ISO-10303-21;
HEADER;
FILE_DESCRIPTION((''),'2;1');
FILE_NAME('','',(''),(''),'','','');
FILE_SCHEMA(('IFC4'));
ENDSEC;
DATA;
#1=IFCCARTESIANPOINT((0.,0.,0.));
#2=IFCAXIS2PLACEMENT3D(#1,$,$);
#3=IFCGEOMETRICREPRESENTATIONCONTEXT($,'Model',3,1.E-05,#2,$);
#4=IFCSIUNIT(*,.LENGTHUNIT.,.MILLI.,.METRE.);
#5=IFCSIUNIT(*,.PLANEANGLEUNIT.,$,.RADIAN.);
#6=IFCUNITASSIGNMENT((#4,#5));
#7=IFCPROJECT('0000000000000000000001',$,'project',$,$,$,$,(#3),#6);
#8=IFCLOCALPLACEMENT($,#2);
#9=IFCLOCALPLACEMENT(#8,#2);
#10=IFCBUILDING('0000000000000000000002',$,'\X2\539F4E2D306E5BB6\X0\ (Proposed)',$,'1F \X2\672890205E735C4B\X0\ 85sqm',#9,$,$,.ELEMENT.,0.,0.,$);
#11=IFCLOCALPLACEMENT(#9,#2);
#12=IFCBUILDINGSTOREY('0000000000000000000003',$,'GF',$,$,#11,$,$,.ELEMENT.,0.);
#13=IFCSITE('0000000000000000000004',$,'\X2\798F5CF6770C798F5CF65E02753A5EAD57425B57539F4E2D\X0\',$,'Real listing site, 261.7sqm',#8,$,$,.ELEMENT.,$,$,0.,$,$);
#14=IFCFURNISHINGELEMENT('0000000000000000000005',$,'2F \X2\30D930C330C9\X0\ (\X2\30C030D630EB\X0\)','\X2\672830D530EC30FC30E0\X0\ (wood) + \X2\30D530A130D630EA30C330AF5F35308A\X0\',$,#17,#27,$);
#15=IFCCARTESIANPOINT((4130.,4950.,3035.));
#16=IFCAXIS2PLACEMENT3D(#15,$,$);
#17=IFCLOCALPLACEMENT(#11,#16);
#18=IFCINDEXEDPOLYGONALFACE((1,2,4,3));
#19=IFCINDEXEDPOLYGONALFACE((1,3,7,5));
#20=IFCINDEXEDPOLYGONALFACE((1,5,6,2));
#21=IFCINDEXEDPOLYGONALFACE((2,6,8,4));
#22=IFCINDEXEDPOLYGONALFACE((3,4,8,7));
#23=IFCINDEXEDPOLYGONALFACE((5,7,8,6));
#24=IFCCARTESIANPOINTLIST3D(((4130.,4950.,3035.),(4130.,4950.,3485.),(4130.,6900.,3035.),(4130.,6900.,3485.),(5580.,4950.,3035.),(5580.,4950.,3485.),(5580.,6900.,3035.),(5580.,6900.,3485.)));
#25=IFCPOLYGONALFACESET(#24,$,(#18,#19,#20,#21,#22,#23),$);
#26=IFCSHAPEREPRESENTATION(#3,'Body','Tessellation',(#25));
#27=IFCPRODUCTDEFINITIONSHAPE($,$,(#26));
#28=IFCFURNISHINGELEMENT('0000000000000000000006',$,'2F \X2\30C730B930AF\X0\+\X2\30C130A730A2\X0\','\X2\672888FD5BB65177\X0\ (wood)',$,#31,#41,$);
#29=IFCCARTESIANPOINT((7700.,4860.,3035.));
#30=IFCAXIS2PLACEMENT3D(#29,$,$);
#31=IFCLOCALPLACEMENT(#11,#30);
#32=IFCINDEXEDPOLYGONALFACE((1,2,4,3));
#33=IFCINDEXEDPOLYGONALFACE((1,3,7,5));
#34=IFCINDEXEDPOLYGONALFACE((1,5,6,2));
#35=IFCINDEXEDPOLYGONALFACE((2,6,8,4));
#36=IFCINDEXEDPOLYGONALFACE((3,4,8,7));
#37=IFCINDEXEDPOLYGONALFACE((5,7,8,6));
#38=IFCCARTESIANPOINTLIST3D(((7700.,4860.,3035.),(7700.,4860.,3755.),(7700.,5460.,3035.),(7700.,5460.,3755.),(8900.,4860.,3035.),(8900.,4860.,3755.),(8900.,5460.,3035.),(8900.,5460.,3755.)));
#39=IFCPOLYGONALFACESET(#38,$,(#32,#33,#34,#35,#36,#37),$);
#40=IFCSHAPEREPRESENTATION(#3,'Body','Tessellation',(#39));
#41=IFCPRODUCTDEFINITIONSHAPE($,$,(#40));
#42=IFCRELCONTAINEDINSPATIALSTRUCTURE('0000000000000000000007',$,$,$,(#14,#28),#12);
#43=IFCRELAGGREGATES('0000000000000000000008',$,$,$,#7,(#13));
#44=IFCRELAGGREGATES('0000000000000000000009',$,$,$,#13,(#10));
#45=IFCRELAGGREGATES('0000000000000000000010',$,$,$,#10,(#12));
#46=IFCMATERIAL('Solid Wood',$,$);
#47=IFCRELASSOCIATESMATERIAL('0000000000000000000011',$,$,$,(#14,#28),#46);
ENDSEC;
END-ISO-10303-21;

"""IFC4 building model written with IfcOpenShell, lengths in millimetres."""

from ifc_helpers import new_model, si_unit, frame, frame_2d, origin, place, context, project, spatial, rectangle, extrude, material, element, save


model = new_model("IFC4")

# Units and contexts
model_context = context("Model", 3, precision=1e-05, world=origin())
ifc_project = project(units=[si_unit("LENGTHUNIT", "METRE", prefix="MILLI"), si_unit("PLANEANGLEUNIT", "RADIAN")], contexts=[model_context])

# Site, building, storey
site_placement = place(None, origin())
site = spatial("IfcSite", under=ifc_project, at=site_placement, Name="福島県福島市町庭坂字原中", ObjectType="Real listing site, 261.7sqm", CompositionType="ELEMENT", RefElevation=0.0)
building_placement = place(site_placement, origin())
building = spatial("IfcBuilding", under=site, at=building_placement, Name="原中の家 (Proposed)", ObjectType="1F 木造平屋 85sqm", CompositionType="ELEMENT", ElevationOfRefHeight=0.0, ElevationOfTerrain=0.0)
storey_placement = place(building_placement, origin())
storey = spatial("IfcBuildingStorey", under=building, at=storey_placement, Name="GF", CompositionType="ELEMENT", Elevation=0.0)

# Shared definitions
ifc_material_1 = material(Name="Solid Wood")

# Furnishing elements
furnishing_1_placement = place(storey_placement, frame((4130.0, 4950.0, 3035.0)))
element("IfcFurnishingElement", 1, at=furnishing_1_placement, inside=storey, material=ifc_material_1, Name="2F ベッド (ダブル)", Description="木フレーム (wood) + ファブリック張り", context=model_context, shape_type="SweptSolid", body=[
    extrude(rectangle(XDim=1450.0, YDim=1950.0, at=frame_2d((725.0, 975.0))), frame((4130.0, 4950.0, 3035.0)), (0.0, 0.0, 1.0), 450.0),
])
furnishing_2_placement = place(storey_placement, frame((7700.0, 4860.0, 3035.0)))
element("IfcFurnishingElement", 2, at=furnishing_2_placement, inside=storey, material=ifc_material_1, Name="2F デスク+チェア", Description="木製家具 (wood)", context=model_context, shape_type="SweptSolid", body=[
    extrude(rectangle(XDim=1200.0, YDim=600.0, at=frame_2d((600.0, 300.0))), frame((7700.0, 4860.0, 3035.0)), (0.0, 0.0, 1.0), 720.0),
])

save(model, "model.ifc")
